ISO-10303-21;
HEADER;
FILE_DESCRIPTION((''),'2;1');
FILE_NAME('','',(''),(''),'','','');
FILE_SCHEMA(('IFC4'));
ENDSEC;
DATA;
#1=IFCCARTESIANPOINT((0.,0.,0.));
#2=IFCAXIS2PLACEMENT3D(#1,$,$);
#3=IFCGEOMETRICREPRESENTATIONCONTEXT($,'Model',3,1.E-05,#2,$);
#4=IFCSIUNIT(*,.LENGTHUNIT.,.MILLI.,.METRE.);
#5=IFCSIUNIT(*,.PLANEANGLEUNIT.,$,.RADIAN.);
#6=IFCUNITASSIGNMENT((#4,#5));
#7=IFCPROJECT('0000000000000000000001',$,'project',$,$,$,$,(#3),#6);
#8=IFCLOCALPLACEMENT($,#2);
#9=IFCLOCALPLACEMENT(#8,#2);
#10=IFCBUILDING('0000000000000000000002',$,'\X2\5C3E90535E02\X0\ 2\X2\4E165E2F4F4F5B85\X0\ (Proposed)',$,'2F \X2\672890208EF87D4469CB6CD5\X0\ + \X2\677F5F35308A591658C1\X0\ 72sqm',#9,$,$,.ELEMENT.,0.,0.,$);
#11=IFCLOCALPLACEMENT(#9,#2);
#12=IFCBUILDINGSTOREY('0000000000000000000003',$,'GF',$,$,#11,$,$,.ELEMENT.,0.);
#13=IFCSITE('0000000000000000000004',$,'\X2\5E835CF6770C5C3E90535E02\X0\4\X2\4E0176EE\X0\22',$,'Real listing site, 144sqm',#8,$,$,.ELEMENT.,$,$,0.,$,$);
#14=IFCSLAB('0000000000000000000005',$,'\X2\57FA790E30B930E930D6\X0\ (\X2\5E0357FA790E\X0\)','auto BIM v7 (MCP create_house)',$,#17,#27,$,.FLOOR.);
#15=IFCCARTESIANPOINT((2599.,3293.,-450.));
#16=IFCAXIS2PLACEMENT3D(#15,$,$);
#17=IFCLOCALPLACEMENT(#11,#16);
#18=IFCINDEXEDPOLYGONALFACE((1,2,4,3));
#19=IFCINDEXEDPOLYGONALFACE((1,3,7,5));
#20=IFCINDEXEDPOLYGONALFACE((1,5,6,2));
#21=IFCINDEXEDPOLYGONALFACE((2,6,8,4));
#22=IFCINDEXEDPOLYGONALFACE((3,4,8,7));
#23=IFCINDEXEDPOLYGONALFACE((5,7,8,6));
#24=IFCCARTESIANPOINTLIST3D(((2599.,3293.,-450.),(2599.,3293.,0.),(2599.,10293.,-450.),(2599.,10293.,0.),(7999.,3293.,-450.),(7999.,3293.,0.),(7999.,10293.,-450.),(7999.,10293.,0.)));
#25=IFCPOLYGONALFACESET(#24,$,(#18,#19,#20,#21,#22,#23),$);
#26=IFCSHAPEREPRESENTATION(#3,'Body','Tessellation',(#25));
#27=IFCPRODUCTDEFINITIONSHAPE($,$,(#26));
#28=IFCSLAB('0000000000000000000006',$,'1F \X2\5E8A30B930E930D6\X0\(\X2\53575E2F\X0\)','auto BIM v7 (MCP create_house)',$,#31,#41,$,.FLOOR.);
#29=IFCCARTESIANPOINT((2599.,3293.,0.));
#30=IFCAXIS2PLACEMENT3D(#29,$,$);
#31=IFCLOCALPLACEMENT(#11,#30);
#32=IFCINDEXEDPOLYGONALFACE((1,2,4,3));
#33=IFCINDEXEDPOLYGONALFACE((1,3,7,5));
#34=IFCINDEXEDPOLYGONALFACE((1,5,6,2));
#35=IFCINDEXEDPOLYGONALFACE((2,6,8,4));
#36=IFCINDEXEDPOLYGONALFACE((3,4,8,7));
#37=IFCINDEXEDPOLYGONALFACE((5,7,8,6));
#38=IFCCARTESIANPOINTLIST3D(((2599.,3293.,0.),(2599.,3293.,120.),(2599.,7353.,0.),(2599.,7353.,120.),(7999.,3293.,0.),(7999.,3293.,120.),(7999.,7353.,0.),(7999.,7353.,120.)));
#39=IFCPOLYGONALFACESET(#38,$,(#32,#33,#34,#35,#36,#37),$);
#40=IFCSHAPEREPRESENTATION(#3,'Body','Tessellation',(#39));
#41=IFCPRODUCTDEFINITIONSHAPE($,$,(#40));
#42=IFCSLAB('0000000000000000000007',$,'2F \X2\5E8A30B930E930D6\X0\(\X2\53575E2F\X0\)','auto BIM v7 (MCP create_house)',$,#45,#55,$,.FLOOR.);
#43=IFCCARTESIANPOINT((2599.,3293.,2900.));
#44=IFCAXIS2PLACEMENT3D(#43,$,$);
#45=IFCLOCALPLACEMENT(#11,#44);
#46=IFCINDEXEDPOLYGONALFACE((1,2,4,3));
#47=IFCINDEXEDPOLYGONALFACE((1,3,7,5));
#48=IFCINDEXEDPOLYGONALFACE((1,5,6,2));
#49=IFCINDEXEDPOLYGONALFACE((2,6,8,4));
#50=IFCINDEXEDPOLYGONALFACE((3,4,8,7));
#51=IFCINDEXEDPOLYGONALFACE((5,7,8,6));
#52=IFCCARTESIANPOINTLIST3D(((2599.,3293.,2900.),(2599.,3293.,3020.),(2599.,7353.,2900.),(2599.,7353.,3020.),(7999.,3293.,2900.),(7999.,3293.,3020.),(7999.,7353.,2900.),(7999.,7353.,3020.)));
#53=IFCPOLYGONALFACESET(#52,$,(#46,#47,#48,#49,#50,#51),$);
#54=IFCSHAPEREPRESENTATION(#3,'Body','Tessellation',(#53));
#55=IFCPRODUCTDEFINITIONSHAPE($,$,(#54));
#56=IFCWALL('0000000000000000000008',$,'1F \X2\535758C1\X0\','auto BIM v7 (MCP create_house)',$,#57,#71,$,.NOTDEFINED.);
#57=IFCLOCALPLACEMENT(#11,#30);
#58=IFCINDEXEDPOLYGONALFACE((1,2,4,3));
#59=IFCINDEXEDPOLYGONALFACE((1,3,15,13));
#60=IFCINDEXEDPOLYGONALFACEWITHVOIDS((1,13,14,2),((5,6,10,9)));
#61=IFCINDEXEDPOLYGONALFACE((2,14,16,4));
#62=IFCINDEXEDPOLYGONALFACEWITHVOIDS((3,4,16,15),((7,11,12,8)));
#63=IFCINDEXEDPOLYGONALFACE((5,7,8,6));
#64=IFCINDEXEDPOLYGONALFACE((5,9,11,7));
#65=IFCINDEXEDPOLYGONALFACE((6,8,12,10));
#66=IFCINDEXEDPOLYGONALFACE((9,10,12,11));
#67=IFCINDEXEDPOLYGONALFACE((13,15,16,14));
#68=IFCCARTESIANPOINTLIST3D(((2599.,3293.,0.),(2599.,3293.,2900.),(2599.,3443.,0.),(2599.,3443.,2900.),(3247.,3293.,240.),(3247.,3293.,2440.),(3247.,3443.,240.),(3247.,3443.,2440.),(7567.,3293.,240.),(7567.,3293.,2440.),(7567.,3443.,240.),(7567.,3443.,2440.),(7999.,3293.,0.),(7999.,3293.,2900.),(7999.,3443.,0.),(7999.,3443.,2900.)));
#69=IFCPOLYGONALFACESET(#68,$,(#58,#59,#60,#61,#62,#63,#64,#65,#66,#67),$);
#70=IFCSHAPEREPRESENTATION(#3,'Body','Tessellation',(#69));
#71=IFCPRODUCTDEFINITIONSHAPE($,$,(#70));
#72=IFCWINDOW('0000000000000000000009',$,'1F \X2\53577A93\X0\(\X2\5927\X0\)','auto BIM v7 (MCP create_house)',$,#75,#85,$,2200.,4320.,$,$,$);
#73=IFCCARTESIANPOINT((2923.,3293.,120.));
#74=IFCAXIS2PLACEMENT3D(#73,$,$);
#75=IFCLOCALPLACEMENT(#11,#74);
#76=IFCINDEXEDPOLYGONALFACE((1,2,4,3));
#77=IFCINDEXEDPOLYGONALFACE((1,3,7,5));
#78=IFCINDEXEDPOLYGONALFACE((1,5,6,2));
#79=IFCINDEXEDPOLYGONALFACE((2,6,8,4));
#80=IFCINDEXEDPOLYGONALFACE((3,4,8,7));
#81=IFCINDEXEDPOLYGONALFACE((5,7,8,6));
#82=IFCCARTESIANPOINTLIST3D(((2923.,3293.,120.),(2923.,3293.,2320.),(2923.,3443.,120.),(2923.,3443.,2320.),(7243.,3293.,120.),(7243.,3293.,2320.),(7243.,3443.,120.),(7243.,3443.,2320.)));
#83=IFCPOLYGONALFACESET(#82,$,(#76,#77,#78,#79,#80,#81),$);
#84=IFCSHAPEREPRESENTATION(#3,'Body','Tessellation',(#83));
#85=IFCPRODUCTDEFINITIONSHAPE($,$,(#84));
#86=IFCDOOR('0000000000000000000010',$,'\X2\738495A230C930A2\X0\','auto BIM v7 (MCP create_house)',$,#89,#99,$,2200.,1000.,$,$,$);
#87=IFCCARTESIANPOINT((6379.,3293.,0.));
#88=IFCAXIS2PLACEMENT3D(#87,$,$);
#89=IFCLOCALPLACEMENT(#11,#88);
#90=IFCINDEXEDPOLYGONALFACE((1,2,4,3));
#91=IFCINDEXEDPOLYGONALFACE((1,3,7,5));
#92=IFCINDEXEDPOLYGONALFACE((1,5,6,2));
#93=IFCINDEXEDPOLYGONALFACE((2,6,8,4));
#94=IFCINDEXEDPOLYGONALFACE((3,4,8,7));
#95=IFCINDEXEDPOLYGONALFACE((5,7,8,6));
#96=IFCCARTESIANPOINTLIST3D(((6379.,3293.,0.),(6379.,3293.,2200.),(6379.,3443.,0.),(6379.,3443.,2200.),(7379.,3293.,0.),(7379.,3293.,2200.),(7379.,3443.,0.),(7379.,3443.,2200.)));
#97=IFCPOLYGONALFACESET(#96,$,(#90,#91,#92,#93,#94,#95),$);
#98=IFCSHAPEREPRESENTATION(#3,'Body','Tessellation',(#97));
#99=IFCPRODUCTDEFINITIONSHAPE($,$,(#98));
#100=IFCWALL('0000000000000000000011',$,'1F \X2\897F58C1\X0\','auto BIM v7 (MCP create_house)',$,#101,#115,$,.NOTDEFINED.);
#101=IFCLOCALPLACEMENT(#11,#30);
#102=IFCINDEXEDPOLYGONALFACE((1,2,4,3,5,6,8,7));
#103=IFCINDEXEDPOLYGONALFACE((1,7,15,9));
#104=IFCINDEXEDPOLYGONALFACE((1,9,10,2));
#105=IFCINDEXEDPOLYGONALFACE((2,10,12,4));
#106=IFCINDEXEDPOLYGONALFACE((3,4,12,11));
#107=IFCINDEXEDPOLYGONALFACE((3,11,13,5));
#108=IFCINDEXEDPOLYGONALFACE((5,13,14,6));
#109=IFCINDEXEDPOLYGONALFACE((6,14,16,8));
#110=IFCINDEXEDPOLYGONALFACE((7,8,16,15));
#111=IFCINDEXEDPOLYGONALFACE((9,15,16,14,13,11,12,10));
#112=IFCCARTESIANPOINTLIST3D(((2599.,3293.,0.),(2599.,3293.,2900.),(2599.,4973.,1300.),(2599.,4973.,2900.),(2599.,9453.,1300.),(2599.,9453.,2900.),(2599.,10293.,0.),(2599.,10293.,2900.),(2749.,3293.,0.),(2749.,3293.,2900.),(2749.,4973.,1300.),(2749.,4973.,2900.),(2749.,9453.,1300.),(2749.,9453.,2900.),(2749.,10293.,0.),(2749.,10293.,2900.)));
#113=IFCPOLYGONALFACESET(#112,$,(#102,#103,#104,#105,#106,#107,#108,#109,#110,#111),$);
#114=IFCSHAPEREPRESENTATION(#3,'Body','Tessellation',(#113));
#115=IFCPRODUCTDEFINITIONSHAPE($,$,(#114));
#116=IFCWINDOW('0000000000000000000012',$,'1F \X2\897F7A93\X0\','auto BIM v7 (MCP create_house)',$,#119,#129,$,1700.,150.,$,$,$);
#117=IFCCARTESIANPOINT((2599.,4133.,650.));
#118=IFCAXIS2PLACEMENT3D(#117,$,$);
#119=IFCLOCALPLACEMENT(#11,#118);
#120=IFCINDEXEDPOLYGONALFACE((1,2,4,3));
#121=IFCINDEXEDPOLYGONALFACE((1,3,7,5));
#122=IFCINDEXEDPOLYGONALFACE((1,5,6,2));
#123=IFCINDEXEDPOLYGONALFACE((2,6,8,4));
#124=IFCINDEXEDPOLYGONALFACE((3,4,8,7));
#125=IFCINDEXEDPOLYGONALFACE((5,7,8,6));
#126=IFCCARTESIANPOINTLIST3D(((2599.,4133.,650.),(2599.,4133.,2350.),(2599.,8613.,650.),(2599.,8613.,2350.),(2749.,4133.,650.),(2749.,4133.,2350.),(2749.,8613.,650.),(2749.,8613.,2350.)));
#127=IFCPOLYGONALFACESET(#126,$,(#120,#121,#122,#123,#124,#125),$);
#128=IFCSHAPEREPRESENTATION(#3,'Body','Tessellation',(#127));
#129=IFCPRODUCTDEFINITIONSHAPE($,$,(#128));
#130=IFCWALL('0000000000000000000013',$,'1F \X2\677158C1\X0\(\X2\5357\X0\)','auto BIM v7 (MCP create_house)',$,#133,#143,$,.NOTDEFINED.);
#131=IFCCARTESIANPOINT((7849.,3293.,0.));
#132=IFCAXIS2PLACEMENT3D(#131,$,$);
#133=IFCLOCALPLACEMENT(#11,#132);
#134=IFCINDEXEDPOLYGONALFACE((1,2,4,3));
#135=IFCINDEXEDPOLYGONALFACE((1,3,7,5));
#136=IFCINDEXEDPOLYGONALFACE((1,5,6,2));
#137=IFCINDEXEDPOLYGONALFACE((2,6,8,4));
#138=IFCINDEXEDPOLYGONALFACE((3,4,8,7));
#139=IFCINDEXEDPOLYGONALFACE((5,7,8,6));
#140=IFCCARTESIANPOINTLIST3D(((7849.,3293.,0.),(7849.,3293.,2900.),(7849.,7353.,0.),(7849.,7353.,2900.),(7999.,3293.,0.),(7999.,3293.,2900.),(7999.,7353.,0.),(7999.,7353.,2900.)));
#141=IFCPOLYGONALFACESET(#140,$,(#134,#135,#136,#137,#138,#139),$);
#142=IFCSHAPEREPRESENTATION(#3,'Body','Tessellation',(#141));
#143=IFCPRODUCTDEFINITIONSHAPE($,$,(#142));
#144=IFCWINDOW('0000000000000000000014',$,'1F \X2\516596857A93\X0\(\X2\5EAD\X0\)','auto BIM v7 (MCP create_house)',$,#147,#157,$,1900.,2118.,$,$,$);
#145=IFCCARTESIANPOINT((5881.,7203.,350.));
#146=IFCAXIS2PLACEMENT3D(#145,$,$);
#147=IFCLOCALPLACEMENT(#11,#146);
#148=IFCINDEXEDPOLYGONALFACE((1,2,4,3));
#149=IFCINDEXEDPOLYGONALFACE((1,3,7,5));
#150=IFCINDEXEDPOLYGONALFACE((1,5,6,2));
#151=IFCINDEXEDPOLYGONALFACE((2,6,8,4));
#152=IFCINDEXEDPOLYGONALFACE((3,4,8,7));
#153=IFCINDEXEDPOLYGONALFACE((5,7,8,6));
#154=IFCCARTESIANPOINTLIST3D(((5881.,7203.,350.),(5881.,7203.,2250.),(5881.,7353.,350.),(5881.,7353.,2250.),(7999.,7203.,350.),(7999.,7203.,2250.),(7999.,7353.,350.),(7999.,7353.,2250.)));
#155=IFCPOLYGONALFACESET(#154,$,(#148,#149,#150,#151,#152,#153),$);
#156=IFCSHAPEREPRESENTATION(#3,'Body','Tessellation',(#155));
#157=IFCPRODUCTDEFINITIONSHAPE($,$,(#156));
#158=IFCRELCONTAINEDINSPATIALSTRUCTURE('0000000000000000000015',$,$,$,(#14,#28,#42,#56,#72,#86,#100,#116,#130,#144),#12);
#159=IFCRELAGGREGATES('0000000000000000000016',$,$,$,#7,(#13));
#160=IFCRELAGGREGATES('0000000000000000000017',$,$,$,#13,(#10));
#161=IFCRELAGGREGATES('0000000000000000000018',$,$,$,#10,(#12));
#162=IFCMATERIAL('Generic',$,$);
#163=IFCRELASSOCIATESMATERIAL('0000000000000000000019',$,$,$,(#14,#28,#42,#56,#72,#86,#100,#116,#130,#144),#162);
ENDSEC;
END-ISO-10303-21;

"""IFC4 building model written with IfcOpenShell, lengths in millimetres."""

from ifc_helpers import new_model, si_unit, frame, frame_2d, origin, place, context, project, spatial, rectangle, extrude, material, element, fill, save


model = new_model("IFC4")

# Units and contexts
model_context = context("Model", 3, precision=1e-05, world=origin())
ifc_project = project(units=[si_unit("LENGTHUNIT", "METRE", prefix="MILLI"), si_unit("PLANEANGLEUNIT", "RADIAN")], contexts=[model_context])

# Site, building, storey
site_placement = place(None, origin())
site = spatial("IfcSite", under=ifc_project, at=site_placement, Name="広島県尾道市4丁目22", ObjectType="Real listing site, 144sqm", CompositionType="ELEMENT", RefElevation=0.0)
building_placement = place(site_placement, origin())
building = spatial("IfcBuilding", under=site, at=building_placement, Name="尾道市 2世帯住宅 (Proposed)", ObjectType="2F 木造軸組構法 + 板張り外壁 72sqm", CompositionType="ELEMENT", ElevationOfRefHeight=0.0, ElevationOfTerrain=0.0)
storey_placement = place(building_placement, origin())
storey = spatial("IfcBuildingStorey", under=building, at=storey_placement, Name="GF", CompositionType="ELEMENT", Elevation=0.0)

# Slabs
ifc_material = material(Name="Generic")
slab_1_placement = place(storey_placement, frame((2599.0, 3293.0, -450.0)))
element("IfcSlab", 1, at=slab_1_placement, inside=storey, material=ifc_material, Name="基礎スラブ (布基礎)", Description="auto BIM v7 (MCP create_house)", PredefinedType="FLOOR", context=model_context, shape_type="SweptSolid", body=[
    extrude(rectangle(XDim=5400.0, YDim=7000.0, at=frame_2d((2700.0, 3500.0))), frame((2599.0, 3293.0, -450.0)), (0.0, 0.0, 1.0), 450.0),
])
slab_2_placement = place(storey_placement, frame((2599.0, 3293.0, 0.0)))
element("IfcSlab", 2, at=slab_2_placement, inside=storey, material=ifc_material, Name="1F 床スラブ(南帯)", Description="auto BIM v7 (MCP create_house)", PredefinedType="FLOOR", context=model_context, shape_type="SweptSolid", body=[
    extrude(rectangle(XDim=5400.0, YDim=4060.0, at=frame_2d((2700.0, 2030.0))), frame((2599.0, 3293.0, 0.0)), (0.0, 0.0, 1.0), 120.0),
])
slab_3_placement = place(storey_placement, frame((2599.0, 3293.0, 2900.0)))
element("IfcSlab", 3, at=slab_3_placement, inside=storey, material=ifc_material, Name="2F 床スラブ(南帯)", Description="auto BIM v7 (MCP create_house)", PredefinedType="FLOOR", context=model_context, shape_type="SweptSolid", body=[
    extrude(rectangle(XDim=5400.0, YDim=4060.0, at=frame_2d((2700.0, 2030.0))), frame((2599.0, 3293.0, 2900.0)), (0.0, 0.0, 1.0), 120.0),
])

# Wall, openings, window, door
wall_1_placement = place(storey_placement, frame((2599.0, 3293.0, 0.0)))
wall_1 = element("IfcWall", 4, at=wall_1_placement, inside=storey, material=ifc_material, Name="1F 南壁", Description="auto BIM v7 (MCP create_house)", PredefinedType="NOTDEFINED", context=model_context, shape_type="SweptSolid", body=[
    extrude(rectangle(XDim=5400.0, YDim=150.0, at=frame_2d((2700.0, 75.0))), frame((2599.0, 3293.0, 0.0)), (0.0, 0.0, 1.0), 2900.0),
])
opening_1_placement = place(storey_placement, frame((2923.0, 3293.0, 120.0)))
opening_1 = element("IfcOpeningElement", 5, at=opening_1_placement, cuts=wall_1, PredefinedType="NOTDEFINED", context=model_context, shape_type="SweptSolid", body=[
    extrude(rectangle(XDim=4320.0, YDim=150.0, at=frame_2d((2160.0, 75.0))), frame((2923.0, 3293.0, 120.0)), (0.0, 0.0, 1.0), 2200.0),
])
opening_2_placement = place(storey_placement, frame((6379.0, 3293.0, 0.0)))
opening_2 = element("IfcOpeningElement", 6, at=opening_2_placement, cuts=wall_1, PredefinedType="NOTDEFINED", context=model_context, shape_type="SweptSolid", body=[
    extrude(rectangle(XDim=1000.0, YDim=150.0, at=frame_2d((500.0, 75.0))), frame((6379.0, 3293.0, 0.0)), (0.0, 0.0, 1.0), 2200.0),
])
window_1_placement = place(storey_placement, frame((2923.0, 3293.0, 120.0)))
window_1 = element("IfcWindow", 7, at=window_1_placement, inside=storey, material=ifc_material, Name="1F 南窓(大)", Description="auto BIM v7 (MCP create_house)", OverallHeight=2200.0, OverallWidth=4320.0, context=model_context, shape_type="SweptSolid", body=[
    extrude(rectangle(XDim=4320.0, YDim=150.0, at=frame_2d((2160.0, 75.0))), frame((2923.0, 3293.0, 120.0)), (0.0, 0.0, 1.0), 2200.0),
])
fill(opening_1, window_1)
door_placement = place(storey_placement, frame((6379.0, 3293.0, 0.0)))
door = element("IfcDoor", 8, at=door_placement, inside=storey, material=ifc_material, Name="玄関ドア", Description="auto BIM v7 (MCP create_house)", OverallHeight=2200.0, OverallWidth=1000.0, context=model_context, shape_type="SweptSolid", body=[
    extrude(rectangle(XDim=1000.0, YDim=150.0, at=frame_2d((500.0, 75.0))), frame((6379.0, 3293.0, 0.0)), (0.0, 0.0, 1.0), 2200.0),
])
fill(opening_2, door)

# Walls, openings, windows
wall_2_placement = place(storey_placement, frame((2599.0, 3293.0, 0.0)))
wall_2 = element("IfcWall", 9, at=wall_2_placement, inside=storey, material=ifc_material, Name="1F 西壁", Description="auto BIM v7 (MCP create_house)", PredefinedType="NOTDEFINED", context=model_context, shape_type="SweptSolid", body=[
    extrude(rectangle(XDim=150.0, YDim=7000.0, at=frame_2d((75.0, 3500.0))), frame((2599.0, 3293.0, 0.0)), (0.0, 0.0, 1.0), 2900.0),
])
opening_3_placement = place(storey_placement, frame((2599.0, 4133.0, 650.0)))
opening_3 = element("IfcOpeningElement", 10, at=opening_3_placement, cuts=wall_2, PredefinedType="NOTDEFINED", context=model_context, shape_type="SweptSolid", body=[
    extrude(rectangle(XDim=150.0, YDim=4480.0, at=frame_2d((75.0, 2240.0))), frame((2599.0, 4133.0, 650.0)), (0.0, 0.0, 1.0), 1700.0),
])
window_2_placement = place(storey_placement, frame((2599.0, 4133.0, 650.0)))
window_2 = element("IfcWindow", 11, at=window_2_placement, inside=storey, material=ifc_material, Name="1F 西窓", Description="auto BIM v7 (MCP create_house)", OverallHeight=1700.0, OverallWidth=150.0, context=model_context, shape_type="SweptSolid", body=[
    extrude(rectangle(XDim=150.0, YDim=4480.0, at=frame_2d((75.0, 2240.0))), frame((2599.0, 4133.0, 650.0)), (0.0, 0.0, 1.0), 1700.0),
])
fill(opening_3, window_2)
wall_3_placement = place(storey_placement, frame((7849.0, 3293.0, 0.0)))
wall_3 = element("IfcWall", 12, at=wall_3_placement, inside=storey, material=ifc_material, Name="1F 東壁(南)", Description="auto BIM v7 (MCP create_house)", PredefinedType="NOTDEFINED", context=model_context, shape_type="SweptSolid", body=[
    extrude(rectangle(XDim=150.0, YDim=4060.0, at=frame_2d((75.0, 2030.0))), frame((7849.0, 3293.0, 0.0)), (0.0, 0.0, 1.0), 2900.0),
])
opening_4_placement = place(storey_placement, frame((5881.0, 7203.0, 350.0)))
opening_4 = element("IfcOpeningElement", 13, at=opening_4_placement, cuts=wall_3, PredefinedType="NOTDEFINED", context=model_context, shape_type="SweptSolid", body=[
    extrude(rectangle(XDim=2118.0, YDim=150.0, at=frame_2d((1059.0, 75.0))), frame((5881.0, 7203.0, 350.0)), (0.0, 0.0, 1.0), 1900.0),
])
window_3_placement = place(storey_placement, frame((5881.0, 7203.0, 350.0)))
window_3 = element("IfcWindow", 14, at=window_3_placement, inside=storey, material=ifc_material, Name="1F 入隅窓(庭)", Description="auto BIM v7 (MCP create_house)", OverallHeight=1900.0, OverallWidth=2118.0, context=model_context, shape_type="SweptSolid", body=[
    extrude(rectangle(XDim=2118.0, YDim=150.0, at=frame_2d((1059.0, 75.0))), frame((5881.0, 7203.0, 350.0)), (0.0, 0.0, 1.0), 1900.0),
])
fill(opening_4, window_3)

save(model, "model.ifc")
